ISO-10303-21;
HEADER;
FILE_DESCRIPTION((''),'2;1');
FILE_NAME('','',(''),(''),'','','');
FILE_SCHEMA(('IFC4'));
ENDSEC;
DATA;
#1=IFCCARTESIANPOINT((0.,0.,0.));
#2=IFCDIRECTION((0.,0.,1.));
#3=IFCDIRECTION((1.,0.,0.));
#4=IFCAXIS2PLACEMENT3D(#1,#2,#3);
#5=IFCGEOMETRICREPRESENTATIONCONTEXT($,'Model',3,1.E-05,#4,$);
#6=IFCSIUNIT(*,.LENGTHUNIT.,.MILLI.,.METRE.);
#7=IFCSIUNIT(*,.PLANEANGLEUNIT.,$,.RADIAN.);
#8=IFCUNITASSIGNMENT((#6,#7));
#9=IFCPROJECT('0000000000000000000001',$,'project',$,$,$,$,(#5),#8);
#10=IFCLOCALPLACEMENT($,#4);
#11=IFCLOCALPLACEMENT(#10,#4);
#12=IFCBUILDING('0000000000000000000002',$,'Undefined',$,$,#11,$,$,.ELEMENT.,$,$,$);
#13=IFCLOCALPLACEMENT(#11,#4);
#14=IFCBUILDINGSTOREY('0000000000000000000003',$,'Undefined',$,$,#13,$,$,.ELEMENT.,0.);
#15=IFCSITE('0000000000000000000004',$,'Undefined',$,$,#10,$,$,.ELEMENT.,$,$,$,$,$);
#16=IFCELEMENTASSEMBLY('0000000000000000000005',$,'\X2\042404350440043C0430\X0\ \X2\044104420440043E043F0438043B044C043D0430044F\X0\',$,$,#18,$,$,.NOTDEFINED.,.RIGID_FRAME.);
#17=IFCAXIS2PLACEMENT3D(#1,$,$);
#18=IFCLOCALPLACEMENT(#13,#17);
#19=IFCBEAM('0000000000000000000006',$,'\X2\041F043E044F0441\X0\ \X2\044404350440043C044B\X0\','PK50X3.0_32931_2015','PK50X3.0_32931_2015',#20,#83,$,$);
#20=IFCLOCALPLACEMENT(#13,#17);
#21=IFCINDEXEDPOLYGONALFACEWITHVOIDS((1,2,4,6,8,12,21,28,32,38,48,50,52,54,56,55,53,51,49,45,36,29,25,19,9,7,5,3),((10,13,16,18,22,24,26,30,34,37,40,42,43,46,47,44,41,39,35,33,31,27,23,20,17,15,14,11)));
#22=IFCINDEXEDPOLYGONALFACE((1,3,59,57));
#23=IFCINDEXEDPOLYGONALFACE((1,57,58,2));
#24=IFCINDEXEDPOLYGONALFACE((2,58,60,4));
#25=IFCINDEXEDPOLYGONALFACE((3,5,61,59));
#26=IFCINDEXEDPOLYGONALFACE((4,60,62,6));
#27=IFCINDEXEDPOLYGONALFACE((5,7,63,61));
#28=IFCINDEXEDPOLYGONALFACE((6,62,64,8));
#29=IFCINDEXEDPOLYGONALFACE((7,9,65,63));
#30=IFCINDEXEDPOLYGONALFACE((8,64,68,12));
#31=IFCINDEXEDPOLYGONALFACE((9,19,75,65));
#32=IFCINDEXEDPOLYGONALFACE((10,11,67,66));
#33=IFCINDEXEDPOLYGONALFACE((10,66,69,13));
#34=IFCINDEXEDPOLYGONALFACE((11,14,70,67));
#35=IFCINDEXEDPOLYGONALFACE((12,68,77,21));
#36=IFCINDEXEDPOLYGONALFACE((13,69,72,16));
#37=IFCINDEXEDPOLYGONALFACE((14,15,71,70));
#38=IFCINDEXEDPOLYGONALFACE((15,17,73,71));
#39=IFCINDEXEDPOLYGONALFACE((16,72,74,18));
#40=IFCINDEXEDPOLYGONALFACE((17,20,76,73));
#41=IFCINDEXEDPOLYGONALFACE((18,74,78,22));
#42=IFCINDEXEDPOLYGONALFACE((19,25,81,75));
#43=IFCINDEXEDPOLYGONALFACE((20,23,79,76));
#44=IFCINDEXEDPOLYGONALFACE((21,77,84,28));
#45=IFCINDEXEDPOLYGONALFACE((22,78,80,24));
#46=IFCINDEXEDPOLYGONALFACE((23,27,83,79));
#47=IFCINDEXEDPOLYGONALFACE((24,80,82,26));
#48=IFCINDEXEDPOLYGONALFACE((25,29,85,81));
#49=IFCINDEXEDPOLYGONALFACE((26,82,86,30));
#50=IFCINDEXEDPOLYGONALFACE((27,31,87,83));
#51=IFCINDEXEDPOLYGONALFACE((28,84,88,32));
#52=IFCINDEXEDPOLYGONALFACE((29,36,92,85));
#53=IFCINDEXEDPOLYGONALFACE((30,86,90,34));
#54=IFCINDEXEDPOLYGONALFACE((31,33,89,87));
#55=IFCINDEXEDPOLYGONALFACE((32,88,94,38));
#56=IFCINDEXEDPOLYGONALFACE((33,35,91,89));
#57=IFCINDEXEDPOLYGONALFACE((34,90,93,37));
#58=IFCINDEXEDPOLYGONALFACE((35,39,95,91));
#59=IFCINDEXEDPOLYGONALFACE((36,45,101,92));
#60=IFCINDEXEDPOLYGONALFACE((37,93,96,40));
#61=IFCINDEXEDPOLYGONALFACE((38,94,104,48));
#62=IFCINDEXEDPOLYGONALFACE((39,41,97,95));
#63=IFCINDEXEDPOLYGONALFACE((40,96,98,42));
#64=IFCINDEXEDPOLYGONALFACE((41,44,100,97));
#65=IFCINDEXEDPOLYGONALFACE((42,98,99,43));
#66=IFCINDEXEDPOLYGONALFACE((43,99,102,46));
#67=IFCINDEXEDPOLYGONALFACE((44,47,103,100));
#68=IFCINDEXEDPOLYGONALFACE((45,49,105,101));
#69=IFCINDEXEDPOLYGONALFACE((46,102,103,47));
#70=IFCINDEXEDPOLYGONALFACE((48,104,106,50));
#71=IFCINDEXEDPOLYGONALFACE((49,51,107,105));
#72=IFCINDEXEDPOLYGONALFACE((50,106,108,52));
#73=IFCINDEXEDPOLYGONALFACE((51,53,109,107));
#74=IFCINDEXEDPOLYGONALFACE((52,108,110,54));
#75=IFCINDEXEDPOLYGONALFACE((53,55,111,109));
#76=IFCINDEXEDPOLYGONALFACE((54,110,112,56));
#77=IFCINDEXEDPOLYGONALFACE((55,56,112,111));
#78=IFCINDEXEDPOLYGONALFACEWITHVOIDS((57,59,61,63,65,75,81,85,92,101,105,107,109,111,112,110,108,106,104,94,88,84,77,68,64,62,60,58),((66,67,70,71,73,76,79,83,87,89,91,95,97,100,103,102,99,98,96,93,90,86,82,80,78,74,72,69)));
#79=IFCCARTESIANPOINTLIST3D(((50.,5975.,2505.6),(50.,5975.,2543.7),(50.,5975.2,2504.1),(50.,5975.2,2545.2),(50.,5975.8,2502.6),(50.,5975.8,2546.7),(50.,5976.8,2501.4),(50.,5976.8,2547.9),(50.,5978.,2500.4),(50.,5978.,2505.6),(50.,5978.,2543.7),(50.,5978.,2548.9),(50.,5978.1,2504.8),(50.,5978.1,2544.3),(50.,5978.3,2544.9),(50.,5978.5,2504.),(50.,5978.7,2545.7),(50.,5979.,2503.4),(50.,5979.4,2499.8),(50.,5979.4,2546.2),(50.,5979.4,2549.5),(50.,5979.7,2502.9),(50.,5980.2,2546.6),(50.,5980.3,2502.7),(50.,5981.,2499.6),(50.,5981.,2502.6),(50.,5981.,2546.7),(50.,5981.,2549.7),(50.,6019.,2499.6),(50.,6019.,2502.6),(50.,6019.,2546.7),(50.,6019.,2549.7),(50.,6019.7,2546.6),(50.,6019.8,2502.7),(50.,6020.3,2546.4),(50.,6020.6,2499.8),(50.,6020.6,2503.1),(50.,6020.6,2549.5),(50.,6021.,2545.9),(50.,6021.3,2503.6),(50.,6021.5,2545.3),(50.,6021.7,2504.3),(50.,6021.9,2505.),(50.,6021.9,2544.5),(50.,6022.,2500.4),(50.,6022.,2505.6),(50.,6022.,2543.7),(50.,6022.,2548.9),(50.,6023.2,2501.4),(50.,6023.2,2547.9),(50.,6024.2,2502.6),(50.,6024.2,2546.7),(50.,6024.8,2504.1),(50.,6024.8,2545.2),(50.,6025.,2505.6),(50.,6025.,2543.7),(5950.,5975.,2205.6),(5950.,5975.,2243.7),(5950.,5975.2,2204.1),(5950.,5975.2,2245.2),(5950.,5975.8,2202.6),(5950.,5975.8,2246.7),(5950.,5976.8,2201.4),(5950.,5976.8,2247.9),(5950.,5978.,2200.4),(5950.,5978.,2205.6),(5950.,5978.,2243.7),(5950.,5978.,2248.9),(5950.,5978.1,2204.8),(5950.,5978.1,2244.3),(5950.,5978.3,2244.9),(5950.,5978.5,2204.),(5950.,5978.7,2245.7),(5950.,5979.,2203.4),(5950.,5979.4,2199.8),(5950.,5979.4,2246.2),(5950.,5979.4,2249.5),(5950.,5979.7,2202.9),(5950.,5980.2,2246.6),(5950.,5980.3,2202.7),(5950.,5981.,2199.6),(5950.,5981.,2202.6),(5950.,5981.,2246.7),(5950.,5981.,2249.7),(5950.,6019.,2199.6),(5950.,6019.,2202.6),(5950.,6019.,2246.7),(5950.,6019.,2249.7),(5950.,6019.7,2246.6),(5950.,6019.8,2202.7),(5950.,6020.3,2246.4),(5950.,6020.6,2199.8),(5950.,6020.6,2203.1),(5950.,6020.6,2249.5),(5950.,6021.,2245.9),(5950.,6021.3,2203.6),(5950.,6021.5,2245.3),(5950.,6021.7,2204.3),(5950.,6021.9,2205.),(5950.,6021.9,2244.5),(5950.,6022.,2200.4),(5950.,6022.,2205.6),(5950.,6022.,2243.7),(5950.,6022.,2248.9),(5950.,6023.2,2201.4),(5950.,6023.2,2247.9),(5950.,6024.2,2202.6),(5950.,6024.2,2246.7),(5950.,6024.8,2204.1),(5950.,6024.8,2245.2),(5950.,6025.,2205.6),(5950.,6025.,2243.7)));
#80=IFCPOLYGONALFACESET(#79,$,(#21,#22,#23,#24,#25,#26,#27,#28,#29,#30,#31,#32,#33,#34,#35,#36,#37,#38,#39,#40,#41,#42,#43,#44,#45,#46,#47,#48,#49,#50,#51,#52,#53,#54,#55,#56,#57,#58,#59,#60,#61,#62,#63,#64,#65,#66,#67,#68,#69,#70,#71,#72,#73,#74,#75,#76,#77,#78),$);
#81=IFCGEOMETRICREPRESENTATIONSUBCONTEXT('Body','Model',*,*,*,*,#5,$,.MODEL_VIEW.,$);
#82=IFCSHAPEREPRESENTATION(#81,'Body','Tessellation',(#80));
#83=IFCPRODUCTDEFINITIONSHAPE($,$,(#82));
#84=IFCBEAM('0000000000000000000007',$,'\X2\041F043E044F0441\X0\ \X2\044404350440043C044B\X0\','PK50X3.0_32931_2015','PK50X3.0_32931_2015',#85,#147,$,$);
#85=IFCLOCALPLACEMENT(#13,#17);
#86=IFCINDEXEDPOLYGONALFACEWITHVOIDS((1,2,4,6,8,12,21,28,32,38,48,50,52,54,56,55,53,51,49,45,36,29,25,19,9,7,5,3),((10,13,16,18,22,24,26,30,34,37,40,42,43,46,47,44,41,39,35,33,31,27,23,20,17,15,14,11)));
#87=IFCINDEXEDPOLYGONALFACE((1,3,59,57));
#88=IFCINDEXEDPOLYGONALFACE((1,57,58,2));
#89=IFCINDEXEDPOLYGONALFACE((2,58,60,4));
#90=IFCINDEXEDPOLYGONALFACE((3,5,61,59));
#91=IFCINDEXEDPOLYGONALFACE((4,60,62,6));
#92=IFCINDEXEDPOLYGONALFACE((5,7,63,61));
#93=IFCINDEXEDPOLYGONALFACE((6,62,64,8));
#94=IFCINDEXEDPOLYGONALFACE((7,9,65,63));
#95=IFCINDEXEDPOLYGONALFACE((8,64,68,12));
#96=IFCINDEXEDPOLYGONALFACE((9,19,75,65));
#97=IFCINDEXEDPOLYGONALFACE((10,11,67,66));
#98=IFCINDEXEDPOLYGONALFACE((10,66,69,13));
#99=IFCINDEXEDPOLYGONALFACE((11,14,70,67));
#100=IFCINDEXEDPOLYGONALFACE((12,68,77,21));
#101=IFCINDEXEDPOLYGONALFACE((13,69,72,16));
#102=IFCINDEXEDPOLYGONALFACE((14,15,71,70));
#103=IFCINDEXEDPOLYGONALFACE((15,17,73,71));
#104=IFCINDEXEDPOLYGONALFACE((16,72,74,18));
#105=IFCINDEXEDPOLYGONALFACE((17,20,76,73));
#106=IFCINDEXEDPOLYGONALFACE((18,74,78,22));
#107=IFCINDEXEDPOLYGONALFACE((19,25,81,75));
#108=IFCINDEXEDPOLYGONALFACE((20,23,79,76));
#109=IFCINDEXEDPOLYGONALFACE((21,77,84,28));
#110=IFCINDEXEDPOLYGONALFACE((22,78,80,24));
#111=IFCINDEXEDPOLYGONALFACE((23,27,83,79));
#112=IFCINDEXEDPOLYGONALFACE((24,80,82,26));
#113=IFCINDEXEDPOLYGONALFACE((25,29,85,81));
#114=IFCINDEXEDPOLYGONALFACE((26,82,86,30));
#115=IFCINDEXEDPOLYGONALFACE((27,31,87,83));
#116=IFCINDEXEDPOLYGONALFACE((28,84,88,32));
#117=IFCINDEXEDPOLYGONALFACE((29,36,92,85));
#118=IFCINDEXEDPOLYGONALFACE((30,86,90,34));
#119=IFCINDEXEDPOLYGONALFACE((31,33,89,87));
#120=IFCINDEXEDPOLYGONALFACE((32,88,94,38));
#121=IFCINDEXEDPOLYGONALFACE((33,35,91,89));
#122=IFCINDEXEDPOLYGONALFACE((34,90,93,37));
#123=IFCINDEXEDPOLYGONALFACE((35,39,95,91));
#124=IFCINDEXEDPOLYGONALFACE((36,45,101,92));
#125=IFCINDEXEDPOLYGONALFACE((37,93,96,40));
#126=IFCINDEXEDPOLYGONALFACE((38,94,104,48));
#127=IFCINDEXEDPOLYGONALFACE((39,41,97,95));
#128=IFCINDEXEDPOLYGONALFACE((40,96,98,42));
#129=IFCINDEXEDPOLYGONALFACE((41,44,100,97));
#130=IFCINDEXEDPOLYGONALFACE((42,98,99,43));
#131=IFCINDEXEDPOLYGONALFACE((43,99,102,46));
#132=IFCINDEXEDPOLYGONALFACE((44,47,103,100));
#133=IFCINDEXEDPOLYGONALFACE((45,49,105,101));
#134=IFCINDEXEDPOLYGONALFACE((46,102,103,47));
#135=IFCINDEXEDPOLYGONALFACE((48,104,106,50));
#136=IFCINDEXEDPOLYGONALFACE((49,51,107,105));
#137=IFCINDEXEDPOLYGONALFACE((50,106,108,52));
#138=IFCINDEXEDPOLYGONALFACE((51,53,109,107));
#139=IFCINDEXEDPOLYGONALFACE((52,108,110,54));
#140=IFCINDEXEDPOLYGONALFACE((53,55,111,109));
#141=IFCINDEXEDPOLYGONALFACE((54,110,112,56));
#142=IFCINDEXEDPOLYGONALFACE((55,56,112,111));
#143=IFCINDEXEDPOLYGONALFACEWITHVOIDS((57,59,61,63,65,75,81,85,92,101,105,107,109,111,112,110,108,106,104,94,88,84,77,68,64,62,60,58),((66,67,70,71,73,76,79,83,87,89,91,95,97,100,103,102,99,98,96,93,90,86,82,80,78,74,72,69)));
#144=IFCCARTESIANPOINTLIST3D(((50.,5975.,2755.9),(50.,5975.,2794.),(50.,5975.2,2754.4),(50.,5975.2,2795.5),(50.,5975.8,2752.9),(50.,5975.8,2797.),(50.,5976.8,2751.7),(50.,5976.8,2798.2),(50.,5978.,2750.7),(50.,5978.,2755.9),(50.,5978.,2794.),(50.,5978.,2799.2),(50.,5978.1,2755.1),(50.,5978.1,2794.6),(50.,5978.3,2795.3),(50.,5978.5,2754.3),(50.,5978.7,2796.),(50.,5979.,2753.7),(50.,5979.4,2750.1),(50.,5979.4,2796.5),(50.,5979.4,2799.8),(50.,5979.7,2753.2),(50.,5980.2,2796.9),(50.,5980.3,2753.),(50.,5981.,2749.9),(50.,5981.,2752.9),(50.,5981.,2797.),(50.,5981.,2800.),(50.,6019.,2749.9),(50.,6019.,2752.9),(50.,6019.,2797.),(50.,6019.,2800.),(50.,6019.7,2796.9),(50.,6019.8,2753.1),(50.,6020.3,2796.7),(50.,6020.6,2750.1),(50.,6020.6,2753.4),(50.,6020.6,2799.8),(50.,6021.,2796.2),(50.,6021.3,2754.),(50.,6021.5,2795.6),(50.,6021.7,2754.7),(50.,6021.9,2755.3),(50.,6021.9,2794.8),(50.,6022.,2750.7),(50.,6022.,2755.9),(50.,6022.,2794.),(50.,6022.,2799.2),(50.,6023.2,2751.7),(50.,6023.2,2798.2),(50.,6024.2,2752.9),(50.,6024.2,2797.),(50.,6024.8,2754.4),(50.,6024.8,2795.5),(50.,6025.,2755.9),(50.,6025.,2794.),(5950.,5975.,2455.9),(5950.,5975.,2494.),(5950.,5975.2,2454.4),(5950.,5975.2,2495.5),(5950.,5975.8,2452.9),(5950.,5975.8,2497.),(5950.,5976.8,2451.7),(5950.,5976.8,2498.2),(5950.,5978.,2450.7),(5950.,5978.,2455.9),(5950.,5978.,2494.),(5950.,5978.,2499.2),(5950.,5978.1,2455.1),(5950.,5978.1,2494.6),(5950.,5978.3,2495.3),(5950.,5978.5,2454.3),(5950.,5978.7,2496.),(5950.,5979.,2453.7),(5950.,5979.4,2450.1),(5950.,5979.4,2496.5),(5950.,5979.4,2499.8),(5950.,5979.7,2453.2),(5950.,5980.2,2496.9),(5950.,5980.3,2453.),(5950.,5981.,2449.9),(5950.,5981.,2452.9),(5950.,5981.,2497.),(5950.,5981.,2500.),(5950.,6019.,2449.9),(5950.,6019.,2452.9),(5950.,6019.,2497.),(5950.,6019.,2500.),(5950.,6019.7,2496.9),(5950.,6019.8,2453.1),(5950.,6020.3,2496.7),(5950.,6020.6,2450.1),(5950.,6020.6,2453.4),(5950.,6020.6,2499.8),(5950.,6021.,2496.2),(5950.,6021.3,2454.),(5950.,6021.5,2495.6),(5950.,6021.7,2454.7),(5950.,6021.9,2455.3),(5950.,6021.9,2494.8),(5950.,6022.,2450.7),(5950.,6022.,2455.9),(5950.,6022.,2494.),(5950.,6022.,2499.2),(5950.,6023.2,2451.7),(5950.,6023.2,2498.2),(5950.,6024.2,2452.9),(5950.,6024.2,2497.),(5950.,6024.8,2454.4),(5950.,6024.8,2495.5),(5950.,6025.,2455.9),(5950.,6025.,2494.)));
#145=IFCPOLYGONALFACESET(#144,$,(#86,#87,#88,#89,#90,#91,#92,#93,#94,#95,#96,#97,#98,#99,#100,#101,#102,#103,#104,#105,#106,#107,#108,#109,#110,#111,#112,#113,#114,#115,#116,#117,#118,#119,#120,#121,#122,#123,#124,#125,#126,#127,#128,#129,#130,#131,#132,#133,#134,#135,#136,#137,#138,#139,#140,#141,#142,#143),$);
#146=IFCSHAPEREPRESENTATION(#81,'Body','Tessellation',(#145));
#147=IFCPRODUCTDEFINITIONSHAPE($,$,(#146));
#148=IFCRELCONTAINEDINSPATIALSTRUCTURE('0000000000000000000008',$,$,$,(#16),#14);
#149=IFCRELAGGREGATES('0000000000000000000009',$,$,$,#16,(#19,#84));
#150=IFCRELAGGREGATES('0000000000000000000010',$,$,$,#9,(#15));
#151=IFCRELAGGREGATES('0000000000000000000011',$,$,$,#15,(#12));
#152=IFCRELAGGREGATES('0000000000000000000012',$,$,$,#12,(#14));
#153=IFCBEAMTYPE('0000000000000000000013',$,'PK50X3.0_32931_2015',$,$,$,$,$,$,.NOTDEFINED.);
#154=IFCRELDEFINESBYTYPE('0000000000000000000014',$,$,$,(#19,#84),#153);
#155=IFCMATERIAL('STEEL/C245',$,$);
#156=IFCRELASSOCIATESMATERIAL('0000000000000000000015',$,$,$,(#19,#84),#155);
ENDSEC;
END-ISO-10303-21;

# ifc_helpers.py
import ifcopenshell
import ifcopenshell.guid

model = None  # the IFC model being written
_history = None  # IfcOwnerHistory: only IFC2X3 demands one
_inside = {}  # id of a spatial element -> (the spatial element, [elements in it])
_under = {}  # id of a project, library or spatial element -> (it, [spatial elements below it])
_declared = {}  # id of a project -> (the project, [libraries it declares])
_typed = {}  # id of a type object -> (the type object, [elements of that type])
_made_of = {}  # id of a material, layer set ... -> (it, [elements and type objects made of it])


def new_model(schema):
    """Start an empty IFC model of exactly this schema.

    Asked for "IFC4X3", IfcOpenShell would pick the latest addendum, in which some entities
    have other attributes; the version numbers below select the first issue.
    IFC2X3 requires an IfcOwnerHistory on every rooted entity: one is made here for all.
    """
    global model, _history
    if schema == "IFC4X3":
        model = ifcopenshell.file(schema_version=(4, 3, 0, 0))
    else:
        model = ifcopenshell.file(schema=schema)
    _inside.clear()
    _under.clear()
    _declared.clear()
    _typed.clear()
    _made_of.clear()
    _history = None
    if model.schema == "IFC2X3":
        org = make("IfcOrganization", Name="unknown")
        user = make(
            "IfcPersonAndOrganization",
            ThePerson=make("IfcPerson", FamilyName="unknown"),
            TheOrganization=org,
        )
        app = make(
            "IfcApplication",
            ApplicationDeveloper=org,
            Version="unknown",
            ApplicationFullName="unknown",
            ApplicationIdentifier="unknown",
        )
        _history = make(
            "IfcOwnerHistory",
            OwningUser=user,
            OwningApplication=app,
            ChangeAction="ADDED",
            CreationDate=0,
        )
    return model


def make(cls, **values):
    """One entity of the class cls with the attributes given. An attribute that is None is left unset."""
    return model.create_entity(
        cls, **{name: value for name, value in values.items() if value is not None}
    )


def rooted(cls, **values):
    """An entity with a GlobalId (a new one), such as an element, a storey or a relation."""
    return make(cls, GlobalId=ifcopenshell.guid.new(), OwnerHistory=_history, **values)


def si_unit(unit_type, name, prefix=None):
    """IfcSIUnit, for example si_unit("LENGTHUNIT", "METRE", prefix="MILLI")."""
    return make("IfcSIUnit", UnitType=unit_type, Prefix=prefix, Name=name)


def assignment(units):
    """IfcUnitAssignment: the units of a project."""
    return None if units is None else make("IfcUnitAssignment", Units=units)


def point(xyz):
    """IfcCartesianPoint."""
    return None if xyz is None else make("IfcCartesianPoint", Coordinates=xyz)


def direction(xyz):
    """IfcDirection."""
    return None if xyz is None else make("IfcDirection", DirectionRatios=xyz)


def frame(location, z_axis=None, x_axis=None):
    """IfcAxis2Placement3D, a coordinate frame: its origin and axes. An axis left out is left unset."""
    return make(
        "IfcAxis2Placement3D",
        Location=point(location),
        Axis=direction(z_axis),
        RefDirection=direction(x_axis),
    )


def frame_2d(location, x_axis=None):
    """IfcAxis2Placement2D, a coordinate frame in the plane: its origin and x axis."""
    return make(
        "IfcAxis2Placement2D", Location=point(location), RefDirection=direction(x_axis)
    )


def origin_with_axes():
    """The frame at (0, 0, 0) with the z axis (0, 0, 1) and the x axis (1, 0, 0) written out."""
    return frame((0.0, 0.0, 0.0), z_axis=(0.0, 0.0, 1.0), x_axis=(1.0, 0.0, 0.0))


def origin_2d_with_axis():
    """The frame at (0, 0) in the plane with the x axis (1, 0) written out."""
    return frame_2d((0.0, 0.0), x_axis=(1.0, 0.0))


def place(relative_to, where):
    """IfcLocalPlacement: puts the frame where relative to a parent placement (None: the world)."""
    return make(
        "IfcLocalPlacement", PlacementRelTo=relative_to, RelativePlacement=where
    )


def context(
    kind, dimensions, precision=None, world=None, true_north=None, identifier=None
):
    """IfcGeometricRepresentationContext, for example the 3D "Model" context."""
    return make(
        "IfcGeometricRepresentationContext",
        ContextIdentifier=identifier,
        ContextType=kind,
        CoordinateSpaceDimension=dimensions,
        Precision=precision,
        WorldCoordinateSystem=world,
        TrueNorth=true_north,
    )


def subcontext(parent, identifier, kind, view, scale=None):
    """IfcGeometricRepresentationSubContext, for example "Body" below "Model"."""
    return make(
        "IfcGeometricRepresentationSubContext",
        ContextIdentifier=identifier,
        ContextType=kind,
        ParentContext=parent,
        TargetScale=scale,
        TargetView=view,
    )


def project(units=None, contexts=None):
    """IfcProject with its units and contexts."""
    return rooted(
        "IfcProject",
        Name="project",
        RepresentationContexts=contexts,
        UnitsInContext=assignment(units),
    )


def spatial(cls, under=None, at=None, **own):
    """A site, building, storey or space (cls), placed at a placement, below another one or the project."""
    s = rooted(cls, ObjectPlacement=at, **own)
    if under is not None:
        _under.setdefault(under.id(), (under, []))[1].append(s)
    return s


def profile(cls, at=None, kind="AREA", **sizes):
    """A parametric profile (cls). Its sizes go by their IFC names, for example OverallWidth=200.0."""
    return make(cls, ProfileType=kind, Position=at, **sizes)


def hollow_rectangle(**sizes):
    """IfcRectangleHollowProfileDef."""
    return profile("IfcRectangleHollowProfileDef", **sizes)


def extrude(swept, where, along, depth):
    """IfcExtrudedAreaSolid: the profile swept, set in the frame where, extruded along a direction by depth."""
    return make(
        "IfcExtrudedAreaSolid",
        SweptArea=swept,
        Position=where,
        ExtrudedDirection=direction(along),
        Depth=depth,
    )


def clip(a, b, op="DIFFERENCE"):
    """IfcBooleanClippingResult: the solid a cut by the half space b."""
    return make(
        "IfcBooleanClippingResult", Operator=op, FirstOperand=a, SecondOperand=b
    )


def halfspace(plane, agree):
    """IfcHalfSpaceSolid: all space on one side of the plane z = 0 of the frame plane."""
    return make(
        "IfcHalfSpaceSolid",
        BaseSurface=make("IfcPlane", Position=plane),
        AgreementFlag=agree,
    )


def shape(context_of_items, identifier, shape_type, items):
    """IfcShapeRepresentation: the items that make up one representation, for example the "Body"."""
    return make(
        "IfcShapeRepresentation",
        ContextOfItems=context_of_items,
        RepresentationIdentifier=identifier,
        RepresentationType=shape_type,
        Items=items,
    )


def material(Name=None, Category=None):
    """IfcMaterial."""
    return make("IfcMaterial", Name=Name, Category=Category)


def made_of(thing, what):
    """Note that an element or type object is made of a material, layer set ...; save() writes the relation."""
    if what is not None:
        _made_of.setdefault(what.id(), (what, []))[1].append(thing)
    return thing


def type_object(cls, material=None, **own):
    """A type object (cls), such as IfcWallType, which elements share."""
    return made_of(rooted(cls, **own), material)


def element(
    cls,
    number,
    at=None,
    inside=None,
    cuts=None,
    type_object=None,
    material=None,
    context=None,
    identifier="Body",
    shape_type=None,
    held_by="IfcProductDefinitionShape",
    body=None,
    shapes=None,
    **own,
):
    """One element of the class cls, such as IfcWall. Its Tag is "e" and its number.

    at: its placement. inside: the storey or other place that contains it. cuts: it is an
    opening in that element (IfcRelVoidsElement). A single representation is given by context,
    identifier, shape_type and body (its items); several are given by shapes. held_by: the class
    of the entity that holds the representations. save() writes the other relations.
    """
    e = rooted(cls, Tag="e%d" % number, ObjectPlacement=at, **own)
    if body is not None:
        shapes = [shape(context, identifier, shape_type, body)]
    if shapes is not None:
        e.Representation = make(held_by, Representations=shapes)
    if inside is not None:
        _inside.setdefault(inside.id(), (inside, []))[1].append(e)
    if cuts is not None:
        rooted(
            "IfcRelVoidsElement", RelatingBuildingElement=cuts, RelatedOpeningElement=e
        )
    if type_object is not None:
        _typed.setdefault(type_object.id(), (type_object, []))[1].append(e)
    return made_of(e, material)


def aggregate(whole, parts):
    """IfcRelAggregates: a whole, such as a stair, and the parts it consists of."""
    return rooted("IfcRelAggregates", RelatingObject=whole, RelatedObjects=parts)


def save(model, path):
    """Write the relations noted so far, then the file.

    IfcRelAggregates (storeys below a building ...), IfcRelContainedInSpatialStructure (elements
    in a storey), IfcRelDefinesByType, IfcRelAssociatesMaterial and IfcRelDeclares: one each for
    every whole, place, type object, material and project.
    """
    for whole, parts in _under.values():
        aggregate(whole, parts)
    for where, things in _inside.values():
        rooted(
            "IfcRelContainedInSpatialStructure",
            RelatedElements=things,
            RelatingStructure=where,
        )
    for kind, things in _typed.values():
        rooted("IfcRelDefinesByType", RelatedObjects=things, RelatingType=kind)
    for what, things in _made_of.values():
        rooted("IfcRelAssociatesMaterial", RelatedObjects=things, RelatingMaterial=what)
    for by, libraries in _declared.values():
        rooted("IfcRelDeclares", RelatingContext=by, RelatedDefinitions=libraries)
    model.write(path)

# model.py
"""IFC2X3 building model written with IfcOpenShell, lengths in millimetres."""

from ifc_helpers import new_model, si_unit, frame, origin_with_axes, origin_2d_with_axis, place, context, subcontext, project, spatial, hollow_rectangle, extrude, clip, halfspace, material, type_object, element, aggregate, save


model = new_model("IFC2X3")

# Units and contexts
model_context = context("Model", 3, precision=1e-05, world=origin_with_axes())
body_context = subcontext(model_context, "Body", "Model", "MODEL_VIEW")
ifc_project = project(units=[si_unit("LENGTHUNIT", "METRE", prefix="MILLI"), si_unit("PLANEANGLEUNIT", "RADIAN")], contexts=[model_context])

# Site, building, storey
site_placement = place(None, origin_with_axes())
site = spatial("IfcSite", under=ifc_project, at=site_placement, Name="Undefined", CompositionType="ELEMENT")
building_placement = place(site_placement, origin_with_axes())
building = spatial("IfcBuilding", under=site, at=building_placement, Name="Undefined", CompositionType="ELEMENT")
storey_placement = place(building_placement, origin_with_axes())
storey = spatial("IfcBuildingStorey", under=building, at=storey_placement, Name="Undefined", CompositionType="ELEMENT", Elevation=0.0)

# Shared definitions
ifc_material_1 = material(Name="STEEL/C245")

# Element assembly
assembly_1_placement = place(storey_placement, origin_with_axes())
assembly_1 = element("IfcElementAssembly", 1, at=assembly_1_placement, inside=storey, Name="Ферма стропильная", AssemblyPlace="NOTDEFINED", PredefinedType="RIGID_FRAME")

# Beams
beam_type_1 = type_object("IfcBeamType", Name="PK50X3.0_32931_2015", PredefinedType="NOTDEFINED")
beam_1_placement = place(assembly_1_placement, frame((36.0, 6000.0, 2525.4), z_axis=(0.050782, 0.0, 0.99871), x_axis=(0.99871, 0.0, -0.050782)))
beam_1 = element("IfcBeam", 2, at=beam_1_placement, type_object=beam_type_1, material=ifc_material_1, Name="Пояс фермы", Description="PK50X3.0_32931_2015", ObjectType="PK50X3.0_32931_2015", context=body_context, shape_type="Clipping", body=[
    clip(clip(extrude(hollow_rectangle(XDim=50.0, YDim=50.0, WallThickness=3.0, InnerFilletRadius=3.0, OuterFilletRadius=6.0, at=origin_2d_with_axis()), frame((5924.2, 0.0, 0.0), z_axis=(-1.0, 0.0, 0.0), x_axis=(0.0, -1.0, 0.0)), (0.0, 0.0, 1.0), 5912.8), halfspace(frame((5907.6, 0.0, 275.0), z_axis=(0.99871, 0.0, 0.050782), x_axis=(0.0, -1.0, 0.0)), False)), halfspace(frame((0.0, 0.0, 275.0), z_axis=(0.99871, 0.0, 0.050782), x_axis=(0.0, -1.0, 0.0)), True)),
])
beam_2_placement = place(assembly_1_placement, frame((48.7, 6000.0, 2775.0), z_axis=(0.050782, 0.0, 0.99871), x_axis=(0.99871, 0.0, -0.050782)))
beam_2 = element("IfcBeam", 3, at=beam_2_placement, type_object=beam_type_1, material=ifc_material_1, Name="Пояс фермы", Description="PK50X3.0_32931_2015", ObjectType="PK50X3.0_32931_2015", context=body_context, shape_type="Clipping", body=[
    clip(clip(extrude(hollow_rectangle(XDim=50.0, YDim=50.0, WallThickness=3.0, InnerFilletRadius=3.0, OuterFilletRadius=6.0, at=origin_2d_with_axis()), frame((5911.5, 0.0, 0.0), z_axis=(-1.0, 0.0, 0.0), x_axis=(0.0, -1.0, 0.0)), (0.0, 0.0, 1.0), 5912.8), halfspace(frame((5907.6, 0.0, 25.0), z_axis=(0.99871, 0.0, 0.050782), x_axis=(0.0, -1.0, 0.0)), False)), halfspace(frame((0.0, 0.0, 25.0), z_axis=(0.99871, 0.0, 0.050782), x_axis=(0.0, -1.0, 0.0)), True)),
])
aggregate(assembly_1, [beam_1, beam_2])

save(model, "model.ifc")
